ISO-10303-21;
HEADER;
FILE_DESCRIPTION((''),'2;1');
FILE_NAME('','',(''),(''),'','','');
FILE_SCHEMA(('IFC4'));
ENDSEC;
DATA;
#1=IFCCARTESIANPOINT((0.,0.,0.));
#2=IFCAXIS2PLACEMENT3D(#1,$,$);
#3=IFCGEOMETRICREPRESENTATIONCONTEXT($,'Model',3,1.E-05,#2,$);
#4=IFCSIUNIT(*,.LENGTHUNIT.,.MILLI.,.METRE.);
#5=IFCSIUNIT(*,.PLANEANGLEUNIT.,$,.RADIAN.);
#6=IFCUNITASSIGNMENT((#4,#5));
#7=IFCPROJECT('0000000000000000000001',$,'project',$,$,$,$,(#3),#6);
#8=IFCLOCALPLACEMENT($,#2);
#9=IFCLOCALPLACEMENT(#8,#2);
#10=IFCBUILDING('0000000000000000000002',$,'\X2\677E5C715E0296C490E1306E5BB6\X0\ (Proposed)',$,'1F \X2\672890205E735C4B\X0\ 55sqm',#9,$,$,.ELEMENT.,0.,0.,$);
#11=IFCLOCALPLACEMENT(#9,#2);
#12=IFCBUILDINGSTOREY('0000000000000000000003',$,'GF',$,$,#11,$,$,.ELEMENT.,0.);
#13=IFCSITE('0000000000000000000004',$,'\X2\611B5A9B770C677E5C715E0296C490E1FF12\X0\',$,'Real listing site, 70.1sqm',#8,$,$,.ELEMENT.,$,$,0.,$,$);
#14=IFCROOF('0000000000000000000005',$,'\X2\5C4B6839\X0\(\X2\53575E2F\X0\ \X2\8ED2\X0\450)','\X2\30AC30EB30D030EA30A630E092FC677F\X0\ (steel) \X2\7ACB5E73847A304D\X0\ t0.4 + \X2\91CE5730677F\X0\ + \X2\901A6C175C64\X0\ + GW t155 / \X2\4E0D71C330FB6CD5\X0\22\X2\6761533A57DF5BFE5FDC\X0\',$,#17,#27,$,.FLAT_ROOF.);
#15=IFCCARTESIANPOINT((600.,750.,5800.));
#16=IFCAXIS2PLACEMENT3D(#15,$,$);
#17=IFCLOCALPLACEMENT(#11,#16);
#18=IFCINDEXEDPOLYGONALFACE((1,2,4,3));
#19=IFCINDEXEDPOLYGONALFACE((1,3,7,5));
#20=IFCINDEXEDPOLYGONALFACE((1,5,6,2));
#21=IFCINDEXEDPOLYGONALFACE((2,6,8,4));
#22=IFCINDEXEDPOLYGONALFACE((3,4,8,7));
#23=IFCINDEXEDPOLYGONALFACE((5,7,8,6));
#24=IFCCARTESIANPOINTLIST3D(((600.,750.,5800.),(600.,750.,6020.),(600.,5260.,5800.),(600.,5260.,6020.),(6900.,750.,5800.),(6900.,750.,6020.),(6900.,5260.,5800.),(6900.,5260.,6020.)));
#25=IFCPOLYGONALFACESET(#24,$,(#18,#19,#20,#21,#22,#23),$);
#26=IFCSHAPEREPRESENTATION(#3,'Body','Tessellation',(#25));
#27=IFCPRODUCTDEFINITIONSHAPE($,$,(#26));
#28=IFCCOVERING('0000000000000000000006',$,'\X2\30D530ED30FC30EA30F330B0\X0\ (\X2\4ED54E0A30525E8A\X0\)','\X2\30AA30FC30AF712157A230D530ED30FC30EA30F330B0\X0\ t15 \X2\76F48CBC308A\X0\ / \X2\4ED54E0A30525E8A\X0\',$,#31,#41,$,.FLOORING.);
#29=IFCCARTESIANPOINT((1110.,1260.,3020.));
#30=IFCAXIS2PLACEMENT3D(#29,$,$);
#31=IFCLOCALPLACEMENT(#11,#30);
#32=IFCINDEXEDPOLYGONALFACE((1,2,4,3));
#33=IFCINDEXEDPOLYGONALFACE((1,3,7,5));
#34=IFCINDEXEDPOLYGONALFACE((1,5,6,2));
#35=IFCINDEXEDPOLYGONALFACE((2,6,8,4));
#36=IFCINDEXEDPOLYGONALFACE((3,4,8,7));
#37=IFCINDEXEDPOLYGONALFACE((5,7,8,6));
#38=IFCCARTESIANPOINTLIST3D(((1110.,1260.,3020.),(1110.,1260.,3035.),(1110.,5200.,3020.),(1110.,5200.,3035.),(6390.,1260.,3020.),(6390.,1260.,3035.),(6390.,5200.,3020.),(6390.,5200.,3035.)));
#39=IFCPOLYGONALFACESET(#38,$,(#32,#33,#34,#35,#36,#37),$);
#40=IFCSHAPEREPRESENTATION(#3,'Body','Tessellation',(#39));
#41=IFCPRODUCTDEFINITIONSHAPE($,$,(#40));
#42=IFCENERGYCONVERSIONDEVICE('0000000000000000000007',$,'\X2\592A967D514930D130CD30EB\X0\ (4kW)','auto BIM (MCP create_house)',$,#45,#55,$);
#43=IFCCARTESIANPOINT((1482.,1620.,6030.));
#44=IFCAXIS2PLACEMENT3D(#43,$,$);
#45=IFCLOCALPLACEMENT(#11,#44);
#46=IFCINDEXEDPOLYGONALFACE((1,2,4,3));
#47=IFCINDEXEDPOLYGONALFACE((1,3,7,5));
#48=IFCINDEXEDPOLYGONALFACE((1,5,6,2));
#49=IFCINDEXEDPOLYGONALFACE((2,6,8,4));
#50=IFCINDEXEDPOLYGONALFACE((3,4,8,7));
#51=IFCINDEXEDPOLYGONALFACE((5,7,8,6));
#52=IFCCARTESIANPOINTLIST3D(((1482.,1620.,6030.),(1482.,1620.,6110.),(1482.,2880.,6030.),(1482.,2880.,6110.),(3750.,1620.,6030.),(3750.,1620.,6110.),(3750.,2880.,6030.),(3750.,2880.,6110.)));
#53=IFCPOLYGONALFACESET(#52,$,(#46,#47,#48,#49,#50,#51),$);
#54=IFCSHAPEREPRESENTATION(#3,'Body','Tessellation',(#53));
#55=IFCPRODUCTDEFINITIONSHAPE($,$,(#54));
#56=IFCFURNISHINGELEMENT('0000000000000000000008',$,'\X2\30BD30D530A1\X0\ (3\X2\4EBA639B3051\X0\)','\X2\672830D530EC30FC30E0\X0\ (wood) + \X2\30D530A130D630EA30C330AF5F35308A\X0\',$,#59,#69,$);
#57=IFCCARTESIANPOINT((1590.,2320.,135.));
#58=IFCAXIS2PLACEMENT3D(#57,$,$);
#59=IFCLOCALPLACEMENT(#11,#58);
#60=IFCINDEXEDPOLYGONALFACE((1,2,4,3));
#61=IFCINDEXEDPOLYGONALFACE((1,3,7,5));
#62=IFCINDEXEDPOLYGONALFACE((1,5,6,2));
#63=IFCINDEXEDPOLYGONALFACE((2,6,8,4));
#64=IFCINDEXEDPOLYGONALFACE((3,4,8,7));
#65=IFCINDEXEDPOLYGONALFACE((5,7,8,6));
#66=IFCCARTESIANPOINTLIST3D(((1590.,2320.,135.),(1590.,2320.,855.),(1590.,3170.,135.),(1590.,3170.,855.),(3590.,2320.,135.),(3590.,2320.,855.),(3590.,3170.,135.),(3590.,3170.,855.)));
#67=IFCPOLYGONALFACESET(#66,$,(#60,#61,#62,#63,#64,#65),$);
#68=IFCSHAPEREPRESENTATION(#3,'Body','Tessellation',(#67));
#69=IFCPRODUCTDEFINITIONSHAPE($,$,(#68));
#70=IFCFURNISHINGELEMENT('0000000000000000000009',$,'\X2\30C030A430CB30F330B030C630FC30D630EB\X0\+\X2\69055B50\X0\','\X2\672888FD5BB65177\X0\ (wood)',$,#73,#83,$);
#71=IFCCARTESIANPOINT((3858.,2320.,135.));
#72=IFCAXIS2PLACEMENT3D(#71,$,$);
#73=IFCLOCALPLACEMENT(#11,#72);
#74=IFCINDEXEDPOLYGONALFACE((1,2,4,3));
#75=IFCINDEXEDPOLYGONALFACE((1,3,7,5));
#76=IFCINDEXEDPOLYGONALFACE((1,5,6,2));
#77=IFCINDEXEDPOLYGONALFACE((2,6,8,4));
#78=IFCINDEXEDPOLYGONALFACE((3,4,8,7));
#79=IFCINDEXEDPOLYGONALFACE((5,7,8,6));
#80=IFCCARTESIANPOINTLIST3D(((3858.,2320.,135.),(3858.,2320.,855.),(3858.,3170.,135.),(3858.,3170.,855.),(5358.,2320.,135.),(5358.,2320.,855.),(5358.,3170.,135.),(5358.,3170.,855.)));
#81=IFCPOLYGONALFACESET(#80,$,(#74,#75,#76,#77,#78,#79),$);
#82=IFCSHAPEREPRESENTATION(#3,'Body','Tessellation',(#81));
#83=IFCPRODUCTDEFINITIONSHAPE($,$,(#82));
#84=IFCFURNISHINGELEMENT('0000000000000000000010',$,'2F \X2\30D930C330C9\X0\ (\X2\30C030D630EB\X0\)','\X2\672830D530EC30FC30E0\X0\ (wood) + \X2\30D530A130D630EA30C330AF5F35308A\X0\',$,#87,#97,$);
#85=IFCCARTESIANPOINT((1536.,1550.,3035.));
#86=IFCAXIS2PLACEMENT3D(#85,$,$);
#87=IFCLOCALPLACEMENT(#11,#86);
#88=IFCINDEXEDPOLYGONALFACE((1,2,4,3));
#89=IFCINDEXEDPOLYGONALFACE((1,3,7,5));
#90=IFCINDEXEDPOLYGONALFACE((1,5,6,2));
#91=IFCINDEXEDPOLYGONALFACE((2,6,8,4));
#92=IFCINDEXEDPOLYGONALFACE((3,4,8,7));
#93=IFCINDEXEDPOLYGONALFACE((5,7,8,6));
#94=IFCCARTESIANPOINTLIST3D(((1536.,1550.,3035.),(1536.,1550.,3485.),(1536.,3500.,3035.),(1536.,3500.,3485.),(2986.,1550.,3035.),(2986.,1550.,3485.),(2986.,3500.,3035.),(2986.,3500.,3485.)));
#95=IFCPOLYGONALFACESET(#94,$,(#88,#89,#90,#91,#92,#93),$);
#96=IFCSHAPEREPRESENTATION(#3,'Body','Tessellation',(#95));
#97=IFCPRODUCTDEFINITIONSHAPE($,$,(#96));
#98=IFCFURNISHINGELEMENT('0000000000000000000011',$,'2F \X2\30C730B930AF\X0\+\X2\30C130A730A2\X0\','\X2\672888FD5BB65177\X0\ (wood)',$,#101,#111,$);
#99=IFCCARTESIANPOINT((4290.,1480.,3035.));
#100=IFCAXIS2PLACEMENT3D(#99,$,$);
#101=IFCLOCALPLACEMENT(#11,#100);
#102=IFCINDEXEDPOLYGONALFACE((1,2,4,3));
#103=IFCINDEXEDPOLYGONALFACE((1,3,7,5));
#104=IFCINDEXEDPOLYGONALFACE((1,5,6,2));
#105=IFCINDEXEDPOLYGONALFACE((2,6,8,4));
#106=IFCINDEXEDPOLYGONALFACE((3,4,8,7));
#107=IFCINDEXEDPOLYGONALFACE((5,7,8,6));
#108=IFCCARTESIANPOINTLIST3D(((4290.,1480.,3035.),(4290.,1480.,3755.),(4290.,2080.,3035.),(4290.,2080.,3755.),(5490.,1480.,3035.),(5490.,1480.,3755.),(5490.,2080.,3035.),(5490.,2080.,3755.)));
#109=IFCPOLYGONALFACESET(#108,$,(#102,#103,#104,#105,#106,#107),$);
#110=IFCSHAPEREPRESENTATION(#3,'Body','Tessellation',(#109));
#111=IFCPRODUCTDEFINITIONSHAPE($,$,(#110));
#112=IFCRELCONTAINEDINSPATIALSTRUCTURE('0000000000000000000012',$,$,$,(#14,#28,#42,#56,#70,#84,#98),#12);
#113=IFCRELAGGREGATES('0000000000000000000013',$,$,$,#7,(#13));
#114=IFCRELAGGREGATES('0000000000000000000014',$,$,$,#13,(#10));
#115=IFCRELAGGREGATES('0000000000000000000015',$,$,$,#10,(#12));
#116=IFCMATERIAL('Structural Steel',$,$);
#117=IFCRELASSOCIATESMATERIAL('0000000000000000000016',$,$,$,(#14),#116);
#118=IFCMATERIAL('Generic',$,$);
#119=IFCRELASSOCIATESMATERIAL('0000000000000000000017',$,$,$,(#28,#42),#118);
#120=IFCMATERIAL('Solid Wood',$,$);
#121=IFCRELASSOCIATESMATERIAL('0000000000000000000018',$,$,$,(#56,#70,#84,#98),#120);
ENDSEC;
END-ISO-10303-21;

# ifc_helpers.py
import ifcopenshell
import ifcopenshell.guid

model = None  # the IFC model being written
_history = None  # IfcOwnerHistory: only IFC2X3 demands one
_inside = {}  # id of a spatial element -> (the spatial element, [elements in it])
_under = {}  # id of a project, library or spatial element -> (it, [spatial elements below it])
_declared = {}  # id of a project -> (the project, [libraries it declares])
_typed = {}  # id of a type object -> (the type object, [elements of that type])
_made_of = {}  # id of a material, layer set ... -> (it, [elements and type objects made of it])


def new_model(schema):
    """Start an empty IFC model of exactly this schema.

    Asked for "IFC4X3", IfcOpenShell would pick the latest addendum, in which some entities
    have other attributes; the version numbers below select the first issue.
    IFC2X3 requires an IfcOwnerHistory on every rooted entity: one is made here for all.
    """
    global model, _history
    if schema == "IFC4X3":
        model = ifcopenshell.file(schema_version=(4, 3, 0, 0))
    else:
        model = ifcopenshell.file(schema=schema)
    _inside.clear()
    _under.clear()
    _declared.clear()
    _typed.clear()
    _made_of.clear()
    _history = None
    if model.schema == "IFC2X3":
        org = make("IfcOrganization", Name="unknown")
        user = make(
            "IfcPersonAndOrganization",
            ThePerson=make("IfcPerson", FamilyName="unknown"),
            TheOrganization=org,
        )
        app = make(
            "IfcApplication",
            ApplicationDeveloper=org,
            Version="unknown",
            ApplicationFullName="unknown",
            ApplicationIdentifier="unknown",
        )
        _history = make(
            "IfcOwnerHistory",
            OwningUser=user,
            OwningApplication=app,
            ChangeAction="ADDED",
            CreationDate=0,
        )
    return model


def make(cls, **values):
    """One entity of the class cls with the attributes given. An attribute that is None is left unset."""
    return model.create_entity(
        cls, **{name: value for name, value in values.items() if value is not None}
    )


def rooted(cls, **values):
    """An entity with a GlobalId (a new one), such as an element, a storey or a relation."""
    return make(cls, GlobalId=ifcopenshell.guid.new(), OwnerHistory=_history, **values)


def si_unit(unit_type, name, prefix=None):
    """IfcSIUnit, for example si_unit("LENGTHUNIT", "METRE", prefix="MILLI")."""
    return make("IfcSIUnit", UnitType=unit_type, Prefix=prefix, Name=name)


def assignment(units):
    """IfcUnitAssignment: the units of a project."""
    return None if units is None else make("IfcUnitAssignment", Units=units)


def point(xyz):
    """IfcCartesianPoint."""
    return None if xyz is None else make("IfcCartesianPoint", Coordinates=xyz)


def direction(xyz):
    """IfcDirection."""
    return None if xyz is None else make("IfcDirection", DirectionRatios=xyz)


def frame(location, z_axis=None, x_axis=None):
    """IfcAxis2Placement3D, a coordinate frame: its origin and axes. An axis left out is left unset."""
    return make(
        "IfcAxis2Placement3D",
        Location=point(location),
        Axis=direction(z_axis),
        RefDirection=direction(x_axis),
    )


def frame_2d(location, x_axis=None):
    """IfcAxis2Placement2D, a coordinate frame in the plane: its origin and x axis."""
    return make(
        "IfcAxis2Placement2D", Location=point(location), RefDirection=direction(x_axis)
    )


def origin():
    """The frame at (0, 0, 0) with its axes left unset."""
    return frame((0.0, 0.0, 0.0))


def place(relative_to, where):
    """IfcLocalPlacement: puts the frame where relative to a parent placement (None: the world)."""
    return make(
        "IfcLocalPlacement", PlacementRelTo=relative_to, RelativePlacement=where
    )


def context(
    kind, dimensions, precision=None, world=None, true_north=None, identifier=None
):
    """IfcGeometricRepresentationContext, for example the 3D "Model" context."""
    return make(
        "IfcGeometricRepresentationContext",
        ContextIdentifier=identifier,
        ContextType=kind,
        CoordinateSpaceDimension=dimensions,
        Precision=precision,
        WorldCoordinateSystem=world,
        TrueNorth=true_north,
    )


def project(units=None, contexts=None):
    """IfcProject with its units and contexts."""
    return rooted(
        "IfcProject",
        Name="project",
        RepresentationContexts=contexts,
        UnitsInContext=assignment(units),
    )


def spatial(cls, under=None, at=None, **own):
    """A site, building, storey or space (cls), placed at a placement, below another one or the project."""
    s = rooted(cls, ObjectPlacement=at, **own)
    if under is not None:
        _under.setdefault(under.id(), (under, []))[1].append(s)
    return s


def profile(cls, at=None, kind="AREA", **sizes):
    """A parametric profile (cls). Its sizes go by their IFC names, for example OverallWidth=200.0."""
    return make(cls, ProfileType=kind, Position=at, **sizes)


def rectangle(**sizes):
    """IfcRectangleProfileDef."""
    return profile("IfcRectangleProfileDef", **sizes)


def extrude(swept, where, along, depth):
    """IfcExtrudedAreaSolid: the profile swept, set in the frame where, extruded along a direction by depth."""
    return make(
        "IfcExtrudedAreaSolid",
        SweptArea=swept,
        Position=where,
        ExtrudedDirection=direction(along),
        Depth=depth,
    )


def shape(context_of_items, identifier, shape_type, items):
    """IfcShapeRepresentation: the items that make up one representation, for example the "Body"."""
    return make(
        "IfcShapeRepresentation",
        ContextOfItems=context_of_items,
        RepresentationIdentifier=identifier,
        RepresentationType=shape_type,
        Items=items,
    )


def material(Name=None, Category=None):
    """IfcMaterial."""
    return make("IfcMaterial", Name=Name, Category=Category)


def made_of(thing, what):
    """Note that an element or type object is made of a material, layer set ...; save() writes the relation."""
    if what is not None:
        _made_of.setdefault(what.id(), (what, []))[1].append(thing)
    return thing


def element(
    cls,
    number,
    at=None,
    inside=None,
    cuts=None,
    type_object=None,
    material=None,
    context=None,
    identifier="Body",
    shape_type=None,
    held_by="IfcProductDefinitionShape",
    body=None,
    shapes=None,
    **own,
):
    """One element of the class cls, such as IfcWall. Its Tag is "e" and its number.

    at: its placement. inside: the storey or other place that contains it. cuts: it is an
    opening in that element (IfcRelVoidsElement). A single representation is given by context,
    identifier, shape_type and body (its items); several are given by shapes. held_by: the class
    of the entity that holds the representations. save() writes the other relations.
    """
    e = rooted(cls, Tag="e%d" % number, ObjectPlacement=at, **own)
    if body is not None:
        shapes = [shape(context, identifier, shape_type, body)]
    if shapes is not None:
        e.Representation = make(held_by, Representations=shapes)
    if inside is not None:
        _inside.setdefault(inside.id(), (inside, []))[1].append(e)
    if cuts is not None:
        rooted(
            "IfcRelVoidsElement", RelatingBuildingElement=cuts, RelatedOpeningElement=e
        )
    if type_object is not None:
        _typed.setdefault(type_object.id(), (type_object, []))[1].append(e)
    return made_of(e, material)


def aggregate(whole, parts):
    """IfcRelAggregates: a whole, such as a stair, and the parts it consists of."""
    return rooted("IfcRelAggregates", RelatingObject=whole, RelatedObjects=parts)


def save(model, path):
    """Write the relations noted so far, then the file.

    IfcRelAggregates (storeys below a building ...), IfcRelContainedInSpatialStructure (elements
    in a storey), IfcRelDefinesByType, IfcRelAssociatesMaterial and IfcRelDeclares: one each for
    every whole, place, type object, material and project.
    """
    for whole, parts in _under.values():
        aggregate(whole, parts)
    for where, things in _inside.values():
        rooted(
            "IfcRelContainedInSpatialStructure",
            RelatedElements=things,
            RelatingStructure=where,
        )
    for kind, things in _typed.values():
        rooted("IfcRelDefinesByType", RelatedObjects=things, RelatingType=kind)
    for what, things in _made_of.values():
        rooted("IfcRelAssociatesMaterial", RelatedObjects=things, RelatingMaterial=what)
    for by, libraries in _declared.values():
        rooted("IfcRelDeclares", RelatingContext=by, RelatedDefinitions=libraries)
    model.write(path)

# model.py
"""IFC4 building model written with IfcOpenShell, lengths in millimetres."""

from ifc_helpers import new_model, si_unit, frame, frame_2d, origin, place, context, project, spatial, rectangle, extrude, material, element, save


model = new_model("IFC4")

# Units and contexts
model_context = context("Model", 3, precision=1e-05, world=origin())
ifc_project = project(units=[si_unit("LENGTHUNIT", "METRE", prefix="MILLI"), si_unit("PLANEANGLEUNIT", "RADIAN")], contexts=[model_context])

# Site, building, storey
site_placement = place(None, origin())
site = spatial("IfcSite", under=ifc_project, at=site_placement, Name="愛媛県松山市雄郡２", ObjectType="Real listing site, 70.1sqm", CompositionType="ELEMENT", RefElevation=0.0)
building_placement = place(site_placement, origin())
building = spatial("IfcBuilding", under=site, at=building_placement, Name="松山市雄郡の家 (Proposed)", ObjectType="1F 木造平屋 55sqm", CompositionType="ELEMENT", ElevationOfRefHeight=0.0, ElevationOfTerrain=0.0)
storey_placement = place(building_placement, origin())
storey = spatial("IfcBuildingStorey", under=building, at=storey_placement, Name="GF", CompositionType="ELEMENT", Elevation=0.0)

# Shared definitions
ifc_material_1 = material(Name="Solid Wood")

# Shared definitions
ifc_material_2 = material(Name="Generic")

# Roof
ifc_material_3 = material(Name="Structural Steel")
for number, where, name in (
    (1, (600.0, 750.0, 5800.0), "屋根(南帯 軒450)"),
):
    element("IfcRoof", number, at=place(storey_placement, frame(where)), inside=storey, material=ifc_material_3, Name=name, Description="ガルバリウム鋼板 (steel) 立平葺き t0.4 + 野地板 + 通気層 + GW t155 / 不燃・法22条区域対応", PredefinedType="FLAT_ROOF", context=model_context, shape_type="SweptSolid", body=[
        extrude(rectangle(XDim=6300.0, YDim=4510.0, at=frame_2d((3150.0, 2255.0))), frame((600.0, 750.0, 5800.0)), (0.0, 0.0, 1.0), 220.0),
    ])

# Covering
covering_placement = place(storey_placement, frame((1110.0, 1260.0, 3020.0)))
element("IfcCovering", 2, at=covering_placement, inside=storey, material=ifc_material_2, Name="フローリング (仕上げ床)", Description="オーク無垢フローリング t15 直貼り / 仕上げ床", PredefinedType="FLOORING", context=model_context, shape_type="SweptSolid", body=[
    extrude(rectangle(XDim=5280.0, YDim=3940.0, at=frame_2d((2640.0, 1970.0))), frame((1110.0, 1260.0, 3020.0)), (0.0, 0.0, 1.0), 15.0),
])

# Energy conversion device
energy_conversion_device_placement = place(storey_placement, frame((1482.0, 1620.0, 6030.0)))
element("IfcEnergyConversionDevice", 3, at=energy_conversion_device_placement, inside=storey, material=ifc_material_2, Name="太陽光パネル (4kW)", Description="auto BIM (MCP create_house)", context=model_context, shape_type="SweptSolid", body=[
    extrude(rectangle(XDim=2268.0, YDim=1260.0, at=frame_2d((1134.0, 630.0))), frame((1482.0, 1620.0, 6030.0)), (0.0, 0.0, 1.0), 80.0),
])

# Furnishing elements
furnishing_1_placement = place(storey_placement, frame((1590.0, 2320.0, 135.0)))
element("IfcFurnishingElement", 4, at=furnishing_1_placement, inside=storey, material=ifc_material_1, Name="ソファ (3人掛け)", Description="木フレーム (wood) + ファブリック張り", context=model_context, shape_type="SweptSolid", body=[
    extrude(rectangle(XDim=2000.0, YDim=850.0, at=frame_2d((1000.0, 425.0))), frame((1590.0, 2320.0, 135.0)), (0.0, 0.0, 1.0), 720.0),
])
furnishing_2_placement = place(storey_placement, frame((3858.0, 2320.0, 135.0)))
element("IfcFurnishingElement", 5, at=furnishing_2_placement, inside=storey, material=ifc_material_1, Name="ダイニングテーブル+椅子", Description="木製家具 (wood)", context=model_context, shape_type="SweptSolid", body=[
    extrude(rectangle(XDim=1500.0, YDim=850.0, at=frame_2d((750.0, 425.0))), frame((3858.0, 2320.0, 135.0)), (0.0, 0.0, 1.0), 720.0),
])
furnishing_3_placement = place(storey_placement, frame((1536.0, 1550.0, 3035.0)))
element("IfcFurnishingElement", 6, at=furnishing_3_placement, inside=storey, material=ifc_material_1, Name="2F ベッド (ダブル)", Description="木フレーム (wood) + ファブリック張り", context=model_context, shape_type="SweptSolid", body=[
    extrude(rectangle(XDim=1450.0, YDim=1950.0, at=frame_2d((725.0, 975.0))), frame((1536.0, 1550.0, 3035.0)), (0.0, 0.0, 1.0), 450.0),
])
furnishing_4_placement = place(storey_placement, frame((4290.0, 1480.0, 3035.0)))
element("IfcFurnishingElement", 7, at=furnishing_4_placement, inside=storey, material=ifc_material_1, Name="2F デスク+チェア", Description="木製家具 (wood)", context=model_context, shape_type="SweptSolid", body=[
    extrude(rectangle(XDim=1200.0, YDim=600.0, at=frame_2d((600.0, 300.0))), frame((4290.0, 1480.0, 3035.0)), (0.0, 0.0, 1.0), 720.0),
])

save(model, "model.ifc")
